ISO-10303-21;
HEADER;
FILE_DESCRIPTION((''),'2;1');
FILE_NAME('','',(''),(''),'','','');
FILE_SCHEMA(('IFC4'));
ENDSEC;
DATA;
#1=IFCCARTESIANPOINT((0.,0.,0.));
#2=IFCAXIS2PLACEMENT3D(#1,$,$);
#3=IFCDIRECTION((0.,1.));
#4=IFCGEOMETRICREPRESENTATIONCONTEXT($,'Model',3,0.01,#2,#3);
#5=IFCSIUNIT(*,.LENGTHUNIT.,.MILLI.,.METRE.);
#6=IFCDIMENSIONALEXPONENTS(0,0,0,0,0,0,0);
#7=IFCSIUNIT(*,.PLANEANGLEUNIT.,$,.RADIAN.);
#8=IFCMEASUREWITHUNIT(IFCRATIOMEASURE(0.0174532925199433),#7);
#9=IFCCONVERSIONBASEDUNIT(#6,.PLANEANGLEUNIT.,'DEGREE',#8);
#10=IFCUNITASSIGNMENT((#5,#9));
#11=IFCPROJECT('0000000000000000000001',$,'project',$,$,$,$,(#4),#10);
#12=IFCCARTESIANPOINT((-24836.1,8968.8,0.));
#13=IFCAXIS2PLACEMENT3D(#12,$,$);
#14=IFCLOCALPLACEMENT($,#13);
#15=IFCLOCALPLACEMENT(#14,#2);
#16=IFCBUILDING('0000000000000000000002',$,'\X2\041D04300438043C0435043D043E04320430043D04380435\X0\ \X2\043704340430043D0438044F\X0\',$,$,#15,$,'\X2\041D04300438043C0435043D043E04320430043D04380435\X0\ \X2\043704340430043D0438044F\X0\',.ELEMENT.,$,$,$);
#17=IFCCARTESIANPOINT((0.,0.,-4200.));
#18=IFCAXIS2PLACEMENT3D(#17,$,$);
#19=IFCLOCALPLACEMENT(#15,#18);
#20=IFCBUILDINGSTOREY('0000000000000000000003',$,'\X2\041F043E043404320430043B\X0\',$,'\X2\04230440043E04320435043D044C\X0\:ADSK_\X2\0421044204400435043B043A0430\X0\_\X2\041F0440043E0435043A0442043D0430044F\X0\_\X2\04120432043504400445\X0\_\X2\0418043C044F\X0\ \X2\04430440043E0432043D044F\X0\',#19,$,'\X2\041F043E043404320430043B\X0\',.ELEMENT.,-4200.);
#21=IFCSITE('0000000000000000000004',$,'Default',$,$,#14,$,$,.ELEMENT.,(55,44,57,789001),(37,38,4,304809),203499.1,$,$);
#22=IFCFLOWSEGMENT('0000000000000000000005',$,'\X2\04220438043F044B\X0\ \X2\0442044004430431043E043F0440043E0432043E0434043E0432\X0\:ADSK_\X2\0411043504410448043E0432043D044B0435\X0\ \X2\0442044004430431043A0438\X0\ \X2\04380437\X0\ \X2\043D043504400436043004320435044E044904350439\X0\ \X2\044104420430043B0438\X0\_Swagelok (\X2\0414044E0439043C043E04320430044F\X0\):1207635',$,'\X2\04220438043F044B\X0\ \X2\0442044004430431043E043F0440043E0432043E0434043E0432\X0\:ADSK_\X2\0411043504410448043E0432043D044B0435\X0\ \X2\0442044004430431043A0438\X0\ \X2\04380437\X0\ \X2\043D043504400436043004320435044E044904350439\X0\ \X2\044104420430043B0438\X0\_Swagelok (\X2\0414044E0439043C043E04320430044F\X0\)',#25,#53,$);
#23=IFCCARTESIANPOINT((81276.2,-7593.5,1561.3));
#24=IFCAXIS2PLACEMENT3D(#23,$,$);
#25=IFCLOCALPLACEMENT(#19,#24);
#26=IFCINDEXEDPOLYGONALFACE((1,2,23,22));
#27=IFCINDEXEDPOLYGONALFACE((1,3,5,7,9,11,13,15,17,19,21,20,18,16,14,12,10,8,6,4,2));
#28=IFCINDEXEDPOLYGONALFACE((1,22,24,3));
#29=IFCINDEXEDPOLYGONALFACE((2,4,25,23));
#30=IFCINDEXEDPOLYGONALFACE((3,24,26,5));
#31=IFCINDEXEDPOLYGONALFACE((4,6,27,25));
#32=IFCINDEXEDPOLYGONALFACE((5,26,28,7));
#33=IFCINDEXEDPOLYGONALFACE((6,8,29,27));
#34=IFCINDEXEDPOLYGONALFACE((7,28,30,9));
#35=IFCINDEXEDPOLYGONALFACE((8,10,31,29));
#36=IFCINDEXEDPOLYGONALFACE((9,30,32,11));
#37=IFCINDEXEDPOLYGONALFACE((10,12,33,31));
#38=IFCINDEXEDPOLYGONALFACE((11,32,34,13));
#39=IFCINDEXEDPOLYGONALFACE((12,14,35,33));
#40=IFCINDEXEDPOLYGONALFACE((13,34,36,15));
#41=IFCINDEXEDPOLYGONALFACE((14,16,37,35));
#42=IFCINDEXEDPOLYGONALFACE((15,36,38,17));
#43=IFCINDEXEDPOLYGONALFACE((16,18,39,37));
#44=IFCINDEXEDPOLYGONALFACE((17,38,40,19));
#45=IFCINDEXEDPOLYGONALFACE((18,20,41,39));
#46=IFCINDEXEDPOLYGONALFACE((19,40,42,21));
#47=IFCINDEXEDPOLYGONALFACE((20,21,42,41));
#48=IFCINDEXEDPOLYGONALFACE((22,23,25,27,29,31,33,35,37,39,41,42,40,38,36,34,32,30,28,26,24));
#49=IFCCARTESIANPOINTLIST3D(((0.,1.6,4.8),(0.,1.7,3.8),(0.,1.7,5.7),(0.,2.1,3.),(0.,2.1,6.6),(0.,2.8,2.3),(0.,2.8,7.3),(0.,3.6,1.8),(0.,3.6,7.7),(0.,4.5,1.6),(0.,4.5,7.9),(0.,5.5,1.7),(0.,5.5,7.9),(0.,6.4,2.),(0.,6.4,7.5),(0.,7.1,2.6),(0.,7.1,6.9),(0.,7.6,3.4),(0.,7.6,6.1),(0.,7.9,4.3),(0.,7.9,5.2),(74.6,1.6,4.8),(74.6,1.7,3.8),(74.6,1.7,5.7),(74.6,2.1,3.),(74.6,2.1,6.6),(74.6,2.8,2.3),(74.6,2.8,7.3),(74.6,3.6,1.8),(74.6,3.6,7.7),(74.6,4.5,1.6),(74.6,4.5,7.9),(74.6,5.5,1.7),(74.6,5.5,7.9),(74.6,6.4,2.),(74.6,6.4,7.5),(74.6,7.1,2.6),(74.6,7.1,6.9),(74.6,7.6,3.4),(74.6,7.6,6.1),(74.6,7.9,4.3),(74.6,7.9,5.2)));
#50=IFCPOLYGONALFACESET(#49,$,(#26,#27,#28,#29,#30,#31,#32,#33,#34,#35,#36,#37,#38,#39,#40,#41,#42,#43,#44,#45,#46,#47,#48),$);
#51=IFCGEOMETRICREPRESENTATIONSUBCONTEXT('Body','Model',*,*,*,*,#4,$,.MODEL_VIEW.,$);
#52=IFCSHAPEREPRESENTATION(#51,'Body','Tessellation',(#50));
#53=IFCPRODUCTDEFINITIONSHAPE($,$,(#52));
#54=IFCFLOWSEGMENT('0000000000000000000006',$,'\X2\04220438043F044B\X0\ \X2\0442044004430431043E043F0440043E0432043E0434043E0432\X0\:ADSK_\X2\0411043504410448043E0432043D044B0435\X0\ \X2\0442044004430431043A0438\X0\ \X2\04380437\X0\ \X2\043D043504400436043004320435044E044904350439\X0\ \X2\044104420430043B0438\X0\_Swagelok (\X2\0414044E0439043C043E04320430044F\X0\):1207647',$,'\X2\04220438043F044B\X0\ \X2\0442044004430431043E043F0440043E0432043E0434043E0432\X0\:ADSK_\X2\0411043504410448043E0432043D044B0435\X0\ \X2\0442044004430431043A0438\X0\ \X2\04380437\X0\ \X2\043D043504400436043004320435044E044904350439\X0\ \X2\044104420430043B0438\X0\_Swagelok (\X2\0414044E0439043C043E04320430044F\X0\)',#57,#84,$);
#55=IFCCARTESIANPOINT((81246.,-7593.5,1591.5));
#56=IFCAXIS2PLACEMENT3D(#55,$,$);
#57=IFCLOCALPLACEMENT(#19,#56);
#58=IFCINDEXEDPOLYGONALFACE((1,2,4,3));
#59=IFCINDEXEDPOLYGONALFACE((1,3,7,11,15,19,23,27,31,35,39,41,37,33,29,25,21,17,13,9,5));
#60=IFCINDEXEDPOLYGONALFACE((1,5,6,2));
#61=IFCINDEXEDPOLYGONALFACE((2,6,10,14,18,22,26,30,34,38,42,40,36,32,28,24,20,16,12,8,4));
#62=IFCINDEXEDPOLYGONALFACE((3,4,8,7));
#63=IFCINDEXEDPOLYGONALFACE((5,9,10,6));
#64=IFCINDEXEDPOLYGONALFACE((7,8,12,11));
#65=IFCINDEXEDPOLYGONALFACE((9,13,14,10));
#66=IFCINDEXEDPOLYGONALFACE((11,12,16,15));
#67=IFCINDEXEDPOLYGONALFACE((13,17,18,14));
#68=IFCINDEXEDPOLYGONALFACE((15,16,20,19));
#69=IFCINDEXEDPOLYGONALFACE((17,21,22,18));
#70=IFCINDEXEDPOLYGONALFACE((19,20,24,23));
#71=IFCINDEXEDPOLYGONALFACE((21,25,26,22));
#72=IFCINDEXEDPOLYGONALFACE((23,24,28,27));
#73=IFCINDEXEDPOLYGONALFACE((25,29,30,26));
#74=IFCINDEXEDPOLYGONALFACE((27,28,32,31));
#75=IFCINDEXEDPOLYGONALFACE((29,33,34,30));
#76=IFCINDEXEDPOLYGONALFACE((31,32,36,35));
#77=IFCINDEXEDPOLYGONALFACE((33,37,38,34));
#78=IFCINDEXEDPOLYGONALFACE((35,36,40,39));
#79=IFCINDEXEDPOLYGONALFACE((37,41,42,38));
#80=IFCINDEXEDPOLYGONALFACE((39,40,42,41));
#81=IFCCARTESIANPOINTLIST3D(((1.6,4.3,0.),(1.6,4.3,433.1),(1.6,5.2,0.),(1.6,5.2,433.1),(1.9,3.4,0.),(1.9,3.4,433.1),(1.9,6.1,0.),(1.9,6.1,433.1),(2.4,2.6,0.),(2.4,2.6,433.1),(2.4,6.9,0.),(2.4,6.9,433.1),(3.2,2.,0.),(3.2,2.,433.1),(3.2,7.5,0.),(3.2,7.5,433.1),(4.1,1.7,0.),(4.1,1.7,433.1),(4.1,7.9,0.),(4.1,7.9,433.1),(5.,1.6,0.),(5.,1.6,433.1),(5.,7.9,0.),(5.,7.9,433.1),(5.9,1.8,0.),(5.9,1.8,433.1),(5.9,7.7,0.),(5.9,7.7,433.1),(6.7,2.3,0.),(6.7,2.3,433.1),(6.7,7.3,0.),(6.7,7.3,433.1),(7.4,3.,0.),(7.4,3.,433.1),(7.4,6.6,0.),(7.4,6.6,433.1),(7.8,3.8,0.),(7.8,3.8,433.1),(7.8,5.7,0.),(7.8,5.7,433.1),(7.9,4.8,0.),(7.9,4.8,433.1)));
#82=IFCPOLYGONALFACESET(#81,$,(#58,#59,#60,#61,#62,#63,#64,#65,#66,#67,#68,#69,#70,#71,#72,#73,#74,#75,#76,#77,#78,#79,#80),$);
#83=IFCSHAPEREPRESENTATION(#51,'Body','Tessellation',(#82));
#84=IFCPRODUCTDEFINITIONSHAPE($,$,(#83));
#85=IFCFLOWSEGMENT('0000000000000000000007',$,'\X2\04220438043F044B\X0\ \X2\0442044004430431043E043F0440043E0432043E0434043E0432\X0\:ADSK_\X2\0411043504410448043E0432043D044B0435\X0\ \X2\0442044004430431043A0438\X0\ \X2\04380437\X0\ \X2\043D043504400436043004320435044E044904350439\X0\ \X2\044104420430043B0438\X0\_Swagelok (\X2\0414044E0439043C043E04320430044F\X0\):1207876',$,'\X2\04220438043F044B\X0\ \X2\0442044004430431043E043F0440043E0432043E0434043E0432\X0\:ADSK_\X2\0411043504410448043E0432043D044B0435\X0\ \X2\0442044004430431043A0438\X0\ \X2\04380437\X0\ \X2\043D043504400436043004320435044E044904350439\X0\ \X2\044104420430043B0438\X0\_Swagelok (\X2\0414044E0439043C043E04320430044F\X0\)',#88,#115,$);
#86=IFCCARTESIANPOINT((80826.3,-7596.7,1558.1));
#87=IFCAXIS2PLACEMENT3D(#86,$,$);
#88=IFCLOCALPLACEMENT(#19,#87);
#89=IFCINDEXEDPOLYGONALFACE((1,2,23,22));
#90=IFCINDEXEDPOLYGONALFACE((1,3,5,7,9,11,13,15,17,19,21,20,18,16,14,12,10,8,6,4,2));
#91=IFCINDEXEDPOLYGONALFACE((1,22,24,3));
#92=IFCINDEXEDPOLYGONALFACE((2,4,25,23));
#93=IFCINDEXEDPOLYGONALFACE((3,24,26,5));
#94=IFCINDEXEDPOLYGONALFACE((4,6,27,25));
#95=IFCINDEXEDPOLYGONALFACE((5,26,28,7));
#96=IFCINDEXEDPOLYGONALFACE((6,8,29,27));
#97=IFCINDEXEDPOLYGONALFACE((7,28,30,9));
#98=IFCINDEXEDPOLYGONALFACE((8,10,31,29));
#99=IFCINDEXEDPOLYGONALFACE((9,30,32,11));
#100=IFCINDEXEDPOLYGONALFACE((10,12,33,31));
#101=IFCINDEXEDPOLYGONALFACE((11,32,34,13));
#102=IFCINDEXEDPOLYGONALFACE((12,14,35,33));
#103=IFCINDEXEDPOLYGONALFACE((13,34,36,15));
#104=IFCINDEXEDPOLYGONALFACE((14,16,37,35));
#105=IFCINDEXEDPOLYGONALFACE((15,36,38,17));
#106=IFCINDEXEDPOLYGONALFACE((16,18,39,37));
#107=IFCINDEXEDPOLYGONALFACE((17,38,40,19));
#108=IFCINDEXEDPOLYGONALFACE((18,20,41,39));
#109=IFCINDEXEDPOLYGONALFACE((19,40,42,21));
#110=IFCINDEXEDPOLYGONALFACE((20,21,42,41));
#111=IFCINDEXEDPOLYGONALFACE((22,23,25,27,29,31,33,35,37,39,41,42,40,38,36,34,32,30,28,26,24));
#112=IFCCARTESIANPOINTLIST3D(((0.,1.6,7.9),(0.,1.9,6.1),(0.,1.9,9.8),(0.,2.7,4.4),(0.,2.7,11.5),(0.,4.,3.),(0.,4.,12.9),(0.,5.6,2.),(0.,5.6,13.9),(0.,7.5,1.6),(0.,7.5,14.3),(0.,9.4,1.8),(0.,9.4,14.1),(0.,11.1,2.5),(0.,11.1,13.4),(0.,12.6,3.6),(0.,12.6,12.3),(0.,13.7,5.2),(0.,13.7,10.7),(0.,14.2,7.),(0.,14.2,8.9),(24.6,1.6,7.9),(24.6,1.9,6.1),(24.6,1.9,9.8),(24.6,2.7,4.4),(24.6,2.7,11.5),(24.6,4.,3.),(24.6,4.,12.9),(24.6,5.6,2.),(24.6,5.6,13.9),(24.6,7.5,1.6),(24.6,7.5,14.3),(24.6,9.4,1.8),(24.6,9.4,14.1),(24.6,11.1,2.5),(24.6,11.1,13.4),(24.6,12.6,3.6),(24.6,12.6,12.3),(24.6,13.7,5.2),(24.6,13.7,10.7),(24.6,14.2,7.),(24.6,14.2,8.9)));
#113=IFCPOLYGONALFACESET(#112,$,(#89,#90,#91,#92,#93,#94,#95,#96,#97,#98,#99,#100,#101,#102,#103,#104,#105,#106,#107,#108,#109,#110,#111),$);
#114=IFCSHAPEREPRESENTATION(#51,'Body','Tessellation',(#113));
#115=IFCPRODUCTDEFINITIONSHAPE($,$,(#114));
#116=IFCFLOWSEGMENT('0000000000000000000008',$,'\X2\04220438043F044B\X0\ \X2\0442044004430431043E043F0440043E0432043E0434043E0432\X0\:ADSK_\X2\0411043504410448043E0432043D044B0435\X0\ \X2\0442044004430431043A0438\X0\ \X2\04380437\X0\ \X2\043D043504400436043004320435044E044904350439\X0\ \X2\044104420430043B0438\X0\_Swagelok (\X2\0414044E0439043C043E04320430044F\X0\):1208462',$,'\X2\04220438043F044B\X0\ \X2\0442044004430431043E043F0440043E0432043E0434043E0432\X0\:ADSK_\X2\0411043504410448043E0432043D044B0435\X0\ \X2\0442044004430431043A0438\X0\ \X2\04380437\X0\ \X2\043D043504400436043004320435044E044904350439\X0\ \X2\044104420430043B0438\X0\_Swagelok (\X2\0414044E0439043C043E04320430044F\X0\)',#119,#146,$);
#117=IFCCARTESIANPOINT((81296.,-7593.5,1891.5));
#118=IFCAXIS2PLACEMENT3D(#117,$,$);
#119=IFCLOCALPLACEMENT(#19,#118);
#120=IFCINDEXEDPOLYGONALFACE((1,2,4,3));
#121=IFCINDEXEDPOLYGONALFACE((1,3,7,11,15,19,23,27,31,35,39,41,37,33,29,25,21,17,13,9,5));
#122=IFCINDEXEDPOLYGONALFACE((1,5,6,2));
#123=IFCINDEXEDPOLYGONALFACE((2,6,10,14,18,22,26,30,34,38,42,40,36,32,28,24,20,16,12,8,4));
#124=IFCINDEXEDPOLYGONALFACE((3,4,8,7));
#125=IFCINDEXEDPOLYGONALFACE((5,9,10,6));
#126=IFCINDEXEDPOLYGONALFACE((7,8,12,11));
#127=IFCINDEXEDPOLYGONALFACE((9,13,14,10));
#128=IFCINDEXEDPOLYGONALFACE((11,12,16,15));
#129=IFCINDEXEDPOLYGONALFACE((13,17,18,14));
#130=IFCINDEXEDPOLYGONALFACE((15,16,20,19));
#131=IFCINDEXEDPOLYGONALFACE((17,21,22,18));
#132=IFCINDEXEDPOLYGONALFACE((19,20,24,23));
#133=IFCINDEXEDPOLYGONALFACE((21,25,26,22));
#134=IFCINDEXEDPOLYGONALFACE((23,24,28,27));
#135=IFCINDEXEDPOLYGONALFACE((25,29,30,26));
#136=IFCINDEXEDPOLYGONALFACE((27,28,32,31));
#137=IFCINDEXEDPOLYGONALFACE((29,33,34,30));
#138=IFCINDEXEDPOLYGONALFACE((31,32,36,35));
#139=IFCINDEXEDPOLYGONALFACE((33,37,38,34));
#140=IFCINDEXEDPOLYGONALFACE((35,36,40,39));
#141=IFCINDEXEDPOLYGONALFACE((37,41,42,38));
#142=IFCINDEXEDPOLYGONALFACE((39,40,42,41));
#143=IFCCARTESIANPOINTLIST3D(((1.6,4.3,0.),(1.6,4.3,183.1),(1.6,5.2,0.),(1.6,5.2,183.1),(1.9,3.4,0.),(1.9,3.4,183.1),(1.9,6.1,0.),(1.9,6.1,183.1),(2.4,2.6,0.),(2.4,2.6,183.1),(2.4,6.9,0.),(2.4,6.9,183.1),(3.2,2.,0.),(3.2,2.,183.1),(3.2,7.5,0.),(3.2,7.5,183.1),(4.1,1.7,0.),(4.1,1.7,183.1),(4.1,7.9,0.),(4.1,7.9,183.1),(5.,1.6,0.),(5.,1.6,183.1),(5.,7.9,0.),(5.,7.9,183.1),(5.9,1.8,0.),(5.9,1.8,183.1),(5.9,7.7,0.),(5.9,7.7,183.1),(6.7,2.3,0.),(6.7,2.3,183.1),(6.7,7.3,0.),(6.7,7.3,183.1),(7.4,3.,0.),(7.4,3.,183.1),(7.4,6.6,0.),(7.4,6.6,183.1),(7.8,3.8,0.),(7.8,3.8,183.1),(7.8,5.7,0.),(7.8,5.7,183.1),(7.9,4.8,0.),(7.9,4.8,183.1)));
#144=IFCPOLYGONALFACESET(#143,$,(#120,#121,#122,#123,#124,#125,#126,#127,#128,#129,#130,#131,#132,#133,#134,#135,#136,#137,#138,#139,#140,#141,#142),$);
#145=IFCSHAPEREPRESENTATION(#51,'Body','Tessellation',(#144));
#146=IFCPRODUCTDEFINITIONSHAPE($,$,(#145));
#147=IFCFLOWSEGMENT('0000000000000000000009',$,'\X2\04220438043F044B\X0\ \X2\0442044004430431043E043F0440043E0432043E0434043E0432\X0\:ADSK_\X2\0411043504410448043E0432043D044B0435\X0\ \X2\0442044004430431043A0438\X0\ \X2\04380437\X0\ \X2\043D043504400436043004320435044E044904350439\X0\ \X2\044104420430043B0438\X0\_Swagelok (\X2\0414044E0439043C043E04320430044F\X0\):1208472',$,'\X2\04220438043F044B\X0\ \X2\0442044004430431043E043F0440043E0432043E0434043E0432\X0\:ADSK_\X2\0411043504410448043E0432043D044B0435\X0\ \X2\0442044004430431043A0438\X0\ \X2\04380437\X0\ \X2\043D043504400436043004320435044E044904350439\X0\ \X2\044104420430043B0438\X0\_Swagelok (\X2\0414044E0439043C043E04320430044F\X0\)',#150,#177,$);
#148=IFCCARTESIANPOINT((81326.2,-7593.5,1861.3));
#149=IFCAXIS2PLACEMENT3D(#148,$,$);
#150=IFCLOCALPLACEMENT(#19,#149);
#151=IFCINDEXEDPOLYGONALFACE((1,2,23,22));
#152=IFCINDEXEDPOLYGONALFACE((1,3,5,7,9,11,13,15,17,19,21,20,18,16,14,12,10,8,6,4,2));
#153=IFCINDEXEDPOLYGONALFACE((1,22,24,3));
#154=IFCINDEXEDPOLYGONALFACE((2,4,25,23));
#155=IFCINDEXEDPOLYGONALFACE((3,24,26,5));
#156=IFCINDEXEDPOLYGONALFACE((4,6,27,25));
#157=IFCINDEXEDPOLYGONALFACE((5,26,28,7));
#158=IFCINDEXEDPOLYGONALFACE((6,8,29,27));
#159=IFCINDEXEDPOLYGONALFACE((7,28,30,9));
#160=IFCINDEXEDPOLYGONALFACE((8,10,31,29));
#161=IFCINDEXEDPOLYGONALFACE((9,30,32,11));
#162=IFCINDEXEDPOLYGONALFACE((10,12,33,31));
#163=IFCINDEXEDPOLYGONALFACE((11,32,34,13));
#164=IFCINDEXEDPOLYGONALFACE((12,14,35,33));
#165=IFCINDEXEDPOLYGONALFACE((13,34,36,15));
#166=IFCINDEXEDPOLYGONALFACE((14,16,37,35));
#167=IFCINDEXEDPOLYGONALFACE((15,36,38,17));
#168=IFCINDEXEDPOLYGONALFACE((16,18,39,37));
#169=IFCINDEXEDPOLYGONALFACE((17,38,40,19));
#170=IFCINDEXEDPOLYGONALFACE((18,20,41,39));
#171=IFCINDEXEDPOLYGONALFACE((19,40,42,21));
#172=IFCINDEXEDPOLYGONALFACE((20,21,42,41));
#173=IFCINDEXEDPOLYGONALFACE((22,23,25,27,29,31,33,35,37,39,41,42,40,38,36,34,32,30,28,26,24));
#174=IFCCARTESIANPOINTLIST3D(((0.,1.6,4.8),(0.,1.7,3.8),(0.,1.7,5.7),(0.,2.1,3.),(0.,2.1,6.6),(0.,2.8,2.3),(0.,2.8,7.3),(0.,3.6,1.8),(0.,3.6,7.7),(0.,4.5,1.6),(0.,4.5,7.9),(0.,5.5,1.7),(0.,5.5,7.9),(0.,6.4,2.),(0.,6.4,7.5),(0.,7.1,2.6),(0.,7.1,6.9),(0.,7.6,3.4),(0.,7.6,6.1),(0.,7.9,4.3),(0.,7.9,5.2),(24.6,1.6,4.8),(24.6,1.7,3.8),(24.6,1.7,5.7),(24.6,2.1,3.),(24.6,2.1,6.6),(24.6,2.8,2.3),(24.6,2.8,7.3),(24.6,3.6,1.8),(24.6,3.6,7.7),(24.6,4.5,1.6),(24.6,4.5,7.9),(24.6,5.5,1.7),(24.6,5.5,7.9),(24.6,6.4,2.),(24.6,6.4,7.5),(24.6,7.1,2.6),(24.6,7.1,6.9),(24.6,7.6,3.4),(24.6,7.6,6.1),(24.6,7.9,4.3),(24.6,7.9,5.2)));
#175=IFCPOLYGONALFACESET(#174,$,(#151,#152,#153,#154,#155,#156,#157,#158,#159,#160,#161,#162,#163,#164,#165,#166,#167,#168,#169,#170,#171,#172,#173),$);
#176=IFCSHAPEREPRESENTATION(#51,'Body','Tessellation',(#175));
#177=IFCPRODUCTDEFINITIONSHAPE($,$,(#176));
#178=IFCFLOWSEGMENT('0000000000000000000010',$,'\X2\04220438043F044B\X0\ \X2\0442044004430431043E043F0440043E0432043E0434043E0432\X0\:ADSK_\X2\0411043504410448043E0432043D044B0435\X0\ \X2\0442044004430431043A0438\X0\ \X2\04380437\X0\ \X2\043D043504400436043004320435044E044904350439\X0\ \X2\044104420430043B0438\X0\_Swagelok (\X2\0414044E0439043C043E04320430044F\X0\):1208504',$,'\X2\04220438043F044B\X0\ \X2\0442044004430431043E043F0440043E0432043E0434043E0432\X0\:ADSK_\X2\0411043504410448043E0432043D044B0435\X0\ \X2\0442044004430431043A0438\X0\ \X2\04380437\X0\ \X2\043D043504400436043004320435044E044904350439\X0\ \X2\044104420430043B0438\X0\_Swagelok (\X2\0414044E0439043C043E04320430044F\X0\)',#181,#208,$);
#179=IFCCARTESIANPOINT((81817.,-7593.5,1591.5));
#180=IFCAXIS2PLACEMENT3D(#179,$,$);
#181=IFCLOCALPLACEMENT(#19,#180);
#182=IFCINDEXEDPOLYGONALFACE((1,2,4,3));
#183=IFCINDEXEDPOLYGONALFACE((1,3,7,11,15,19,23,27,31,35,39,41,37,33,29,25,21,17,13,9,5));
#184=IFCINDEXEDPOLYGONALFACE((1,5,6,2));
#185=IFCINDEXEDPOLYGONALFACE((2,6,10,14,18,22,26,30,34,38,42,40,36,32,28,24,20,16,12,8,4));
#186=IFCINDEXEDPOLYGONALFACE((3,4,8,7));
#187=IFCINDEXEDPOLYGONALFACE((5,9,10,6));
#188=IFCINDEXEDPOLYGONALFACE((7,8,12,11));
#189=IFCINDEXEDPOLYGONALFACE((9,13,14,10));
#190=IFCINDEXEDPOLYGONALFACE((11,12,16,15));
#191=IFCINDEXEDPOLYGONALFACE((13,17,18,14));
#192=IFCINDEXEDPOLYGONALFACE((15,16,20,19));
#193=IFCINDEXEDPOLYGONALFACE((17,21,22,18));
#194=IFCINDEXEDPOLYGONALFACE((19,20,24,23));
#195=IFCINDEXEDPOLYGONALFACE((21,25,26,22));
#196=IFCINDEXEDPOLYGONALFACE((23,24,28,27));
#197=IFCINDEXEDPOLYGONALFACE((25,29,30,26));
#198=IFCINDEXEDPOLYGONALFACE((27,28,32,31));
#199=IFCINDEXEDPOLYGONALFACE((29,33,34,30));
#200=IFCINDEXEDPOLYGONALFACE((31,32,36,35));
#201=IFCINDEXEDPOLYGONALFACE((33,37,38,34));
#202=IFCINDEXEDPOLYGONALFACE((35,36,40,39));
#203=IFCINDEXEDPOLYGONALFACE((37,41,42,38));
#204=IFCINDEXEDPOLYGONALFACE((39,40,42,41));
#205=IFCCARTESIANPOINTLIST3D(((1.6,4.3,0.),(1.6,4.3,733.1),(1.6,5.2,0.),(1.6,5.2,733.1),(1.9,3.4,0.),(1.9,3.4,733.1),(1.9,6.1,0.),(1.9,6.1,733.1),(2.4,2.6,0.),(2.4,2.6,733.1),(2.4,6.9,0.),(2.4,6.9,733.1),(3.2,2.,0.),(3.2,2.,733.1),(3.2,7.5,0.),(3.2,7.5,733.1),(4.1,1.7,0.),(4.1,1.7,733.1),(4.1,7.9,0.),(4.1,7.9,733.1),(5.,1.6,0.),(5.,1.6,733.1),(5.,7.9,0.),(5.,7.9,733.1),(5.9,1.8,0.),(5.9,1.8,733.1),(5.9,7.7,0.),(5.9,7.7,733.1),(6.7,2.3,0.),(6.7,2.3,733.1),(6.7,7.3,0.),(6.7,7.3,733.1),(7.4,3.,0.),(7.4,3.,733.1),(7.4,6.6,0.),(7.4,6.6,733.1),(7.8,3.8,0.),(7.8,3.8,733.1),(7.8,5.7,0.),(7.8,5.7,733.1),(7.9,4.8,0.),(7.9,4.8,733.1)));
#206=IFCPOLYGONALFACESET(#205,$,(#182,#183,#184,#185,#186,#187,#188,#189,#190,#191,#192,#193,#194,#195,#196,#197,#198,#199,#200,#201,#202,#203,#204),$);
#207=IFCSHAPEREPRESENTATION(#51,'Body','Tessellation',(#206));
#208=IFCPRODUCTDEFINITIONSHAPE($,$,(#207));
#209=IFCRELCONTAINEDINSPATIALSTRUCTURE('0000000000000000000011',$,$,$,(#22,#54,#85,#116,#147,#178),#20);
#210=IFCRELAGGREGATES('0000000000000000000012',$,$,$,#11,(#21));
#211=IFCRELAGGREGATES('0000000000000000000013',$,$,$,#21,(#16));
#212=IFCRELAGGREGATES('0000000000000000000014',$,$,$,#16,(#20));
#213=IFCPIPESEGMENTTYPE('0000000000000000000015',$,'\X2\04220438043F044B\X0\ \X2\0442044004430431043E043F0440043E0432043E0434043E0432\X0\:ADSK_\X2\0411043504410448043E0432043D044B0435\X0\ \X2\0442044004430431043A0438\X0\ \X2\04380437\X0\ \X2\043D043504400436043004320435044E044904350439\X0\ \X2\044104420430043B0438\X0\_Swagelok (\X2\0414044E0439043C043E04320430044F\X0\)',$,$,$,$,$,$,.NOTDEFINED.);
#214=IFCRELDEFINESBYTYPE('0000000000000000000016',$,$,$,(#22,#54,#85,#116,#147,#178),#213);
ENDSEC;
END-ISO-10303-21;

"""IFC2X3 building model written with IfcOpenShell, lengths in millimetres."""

from ifc_helpers import new_model, entity, si_unit, converted_unit, direction, frame, origin, origin_2d_with_axis, place, context, subcontext, project, spatial, circle, extrude, type_object, element, save


model = new_model("IFC2X3")

# Units and contexts
model_context = context("Model", 3, precision=0.01, world=origin(), true_north=direction((0.0, 1.0)))
body_context = subcontext(model_context, "Body", "Model", "MODEL_VIEW")
ifc_project = project(units=[si_unit("LENGTHUNIT", "METRE", prefix="MILLI"), converted_unit("PLANEANGLEUNIT", "DEGREE", entity("IfcRatioMeasure", 0.0174532925199433), si_unit("PLANEANGLEUNIT", "RADIAN"), dimensions=[0, 0, 0, 0, 0, 0, 0])], contexts=[model_context])

# Site, building, storey
site_placement = place(None, frame((-24836.1, 8968.8, 0.0)))
site = spatial("IfcSite", under=ifc_project, at=site_placement, Name="Default", CompositionType="ELEMENT", RefLatitude=(55, 44, 57, 789001), RefLongitude=(37, 38, 4, 304809), RefElevation=203499.1)
building_placement = place(site_placement, origin())
building = spatial("IfcBuilding", under=site, at=building_placement, Name="Наименование здания", LongName="Наименование здания", CompositionType="ELEMENT")
storey_placement = place(building_placement, frame((0.0, 0.0, -4200.0)))
storey = spatial("IfcBuildingStorey", under=building, at=storey_placement, Name="Подвал", ObjectType="Уровень:ADSK_Стрелка_Проектная_Вверх_Имя уровня", LongName="Подвал", CompositionType="ELEMENT", Elevation=-4200.0)

# Flow segments
pipe_segment_type = type_object("IfcPipeSegmentType", Name="Типы трубопроводов:ADSK_Бесшовные трубки из нержавеющей стали_Swagelok (Дюймовая)", PredefinedType="NOTDEFINED")
flow_segment_1_placement = place(storey_placement, frame((81276.2, -7593.5, 1561.3)))
element("IfcFlowSegment", 1, at=flow_segment_1_placement, inside=storey, type_object=pipe_segment_type, Name="Типы трубопроводов:ADSK_Бесшовные трубки из нержавеющей стали_Swagelok (Дюймовая):1207635", ObjectType="Типы трубопроводов:ADSK_Бесшовные трубки из нержавеющей стали_Swagelok (Дюймовая)", context=body_context, shape_type="SweptSolid", body=[
    extrude(circle(Radius=3.2, at=origin_2d_with_axis()), frame((0.0, 4.8, 4.8), z_axis=(1.0, 0.0, 0.0), x_axis=(0.0, -1.0, 0.0)), (0.0, 0.0, 1.0), 74.6),
])
flow_segment_2_placement = place(storey_placement, frame((81246.0, -7593.5, 1591.5)))
element("IfcFlowSegment", 2, at=flow_segment_2_placement, inside=storey, type_object=pipe_segment_type, Name="Типы трубопроводов:ADSK_Бесшовные трубки из нержавеющей стали_Swagelok (Дюймовая):1207647", ObjectType="Типы трубопроводов:ADSK_Бесшовные трубки из нержавеющей стали_Swagelok (Дюймовая)", context=body_context, shape_type="SweptSolid", body=[
    extrude(circle(Radius=3.2, at=origin_2d_with_axis()), frame((4.8, 4.8, 0.0)), (0.0, 0.0, 1.0), 433.1),
])
flow_segment_3_placement = place(storey_placement, frame((80826.3, -7596.7, 1558.1)))
element("IfcFlowSegment", 3, at=flow_segment_3_placement, inside=storey, type_object=pipe_segment_type, Name="Типы трубопроводов:ADSK_Бесшовные трубки из нержавеющей стали_Swagelok (Дюймовая):1207876", ObjectType="Типы трубопроводов:ADSK_Бесшовные трубки из нержавеющей стали_Swagelok (Дюймовая)", context=body_context, shape_type="SweptSolid", body=[
    extrude(circle(Radius=6.3, at=origin_2d_with_axis()), frame((0.0, 8.0, 8.0), z_axis=(1.0, 0.0, 0.0), x_axis=(0.0, -1.0, 0.0)), (0.0, 0.0, 1.0), 24.6),
])
flow_segment_4_placement = place(storey_placement, frame((81296.0, -7593.5, 1891.5)))
element("IfcFlowSegment", 4, at=flow_segment_4_placement, inside=storey, type_object=pipe_segment_type, Name="Типы трубопроводов:ADSK_Бесшовные трубки из нержавеющей стали_Swagelok (Дюймовая):1208462", ObjectType="Типы трубопроводов:ADSK_Бесшовные трубки из нержавеющей стали_Swagelok (Дюймовая)", context=body_context, shape_type="SweptSolid", body=[
    extrude(circle(Radius=3.2, at=origin_2d_with_axis()), frame((4.8, 4.8, 0.0)), (0.0, 0.0, 1.0), 183.1),
])
flow_segment_5_placement = place(storey_placement, frame((81326.2, -7593.5, 1861.3)))
element("IfcFlowSegment", 5, at=flow_segment_5_placement, inside=storey, type_object=pipe_segment_type, Name="Типы трубопроводов:ADSK_Бесшовные трубки из нержавеющей стали_Swagelok (Дюймовая):1208472", ObjectType="Типы трубопроводов:ADSK_Бесшовные трубки из нержавеющей стали_Swagelok (Дюймовая)", context=body_context, shape_type="SweptSolid", body=[
    extrude(circle(Radius=3.2, at=origin_2d_with_axis()), frame((0.0, 4.8, 4.8), z_axis=(1.0, 0.0, 0.0), x_axis=(0.0, -1.0, 0.0)), (0.0, 0.0, 1.0), 24.6),
])
flow_segment_6_placement = place(storey_placement, frame((81817.0, -7593.5, 1591.5)))
element("IfcFlowSegment", 6, at=flow_segment_6_placement, inside=storey, type_object=pipe_segment_type, Name="Типы трубопроводов:ADSK_Бесшовные трубки из нержавеющей стали_Swagelok (Дюймовая):1208504", ObjectType="Типы трубопроводов:ADSK_Бесшовные трубки из нержавеющей стали_Swagelok (Дюймовая)", context=body_context, shape_type="SweptSolid", body=[
    extrude(circle(Radius=3.2, at=origin_2d_with_axis()), frame((4.8, 4.8, 0.0)), (0.0, 0.0, 1.0), 733.1),
])

save(model, "model.ifc")
